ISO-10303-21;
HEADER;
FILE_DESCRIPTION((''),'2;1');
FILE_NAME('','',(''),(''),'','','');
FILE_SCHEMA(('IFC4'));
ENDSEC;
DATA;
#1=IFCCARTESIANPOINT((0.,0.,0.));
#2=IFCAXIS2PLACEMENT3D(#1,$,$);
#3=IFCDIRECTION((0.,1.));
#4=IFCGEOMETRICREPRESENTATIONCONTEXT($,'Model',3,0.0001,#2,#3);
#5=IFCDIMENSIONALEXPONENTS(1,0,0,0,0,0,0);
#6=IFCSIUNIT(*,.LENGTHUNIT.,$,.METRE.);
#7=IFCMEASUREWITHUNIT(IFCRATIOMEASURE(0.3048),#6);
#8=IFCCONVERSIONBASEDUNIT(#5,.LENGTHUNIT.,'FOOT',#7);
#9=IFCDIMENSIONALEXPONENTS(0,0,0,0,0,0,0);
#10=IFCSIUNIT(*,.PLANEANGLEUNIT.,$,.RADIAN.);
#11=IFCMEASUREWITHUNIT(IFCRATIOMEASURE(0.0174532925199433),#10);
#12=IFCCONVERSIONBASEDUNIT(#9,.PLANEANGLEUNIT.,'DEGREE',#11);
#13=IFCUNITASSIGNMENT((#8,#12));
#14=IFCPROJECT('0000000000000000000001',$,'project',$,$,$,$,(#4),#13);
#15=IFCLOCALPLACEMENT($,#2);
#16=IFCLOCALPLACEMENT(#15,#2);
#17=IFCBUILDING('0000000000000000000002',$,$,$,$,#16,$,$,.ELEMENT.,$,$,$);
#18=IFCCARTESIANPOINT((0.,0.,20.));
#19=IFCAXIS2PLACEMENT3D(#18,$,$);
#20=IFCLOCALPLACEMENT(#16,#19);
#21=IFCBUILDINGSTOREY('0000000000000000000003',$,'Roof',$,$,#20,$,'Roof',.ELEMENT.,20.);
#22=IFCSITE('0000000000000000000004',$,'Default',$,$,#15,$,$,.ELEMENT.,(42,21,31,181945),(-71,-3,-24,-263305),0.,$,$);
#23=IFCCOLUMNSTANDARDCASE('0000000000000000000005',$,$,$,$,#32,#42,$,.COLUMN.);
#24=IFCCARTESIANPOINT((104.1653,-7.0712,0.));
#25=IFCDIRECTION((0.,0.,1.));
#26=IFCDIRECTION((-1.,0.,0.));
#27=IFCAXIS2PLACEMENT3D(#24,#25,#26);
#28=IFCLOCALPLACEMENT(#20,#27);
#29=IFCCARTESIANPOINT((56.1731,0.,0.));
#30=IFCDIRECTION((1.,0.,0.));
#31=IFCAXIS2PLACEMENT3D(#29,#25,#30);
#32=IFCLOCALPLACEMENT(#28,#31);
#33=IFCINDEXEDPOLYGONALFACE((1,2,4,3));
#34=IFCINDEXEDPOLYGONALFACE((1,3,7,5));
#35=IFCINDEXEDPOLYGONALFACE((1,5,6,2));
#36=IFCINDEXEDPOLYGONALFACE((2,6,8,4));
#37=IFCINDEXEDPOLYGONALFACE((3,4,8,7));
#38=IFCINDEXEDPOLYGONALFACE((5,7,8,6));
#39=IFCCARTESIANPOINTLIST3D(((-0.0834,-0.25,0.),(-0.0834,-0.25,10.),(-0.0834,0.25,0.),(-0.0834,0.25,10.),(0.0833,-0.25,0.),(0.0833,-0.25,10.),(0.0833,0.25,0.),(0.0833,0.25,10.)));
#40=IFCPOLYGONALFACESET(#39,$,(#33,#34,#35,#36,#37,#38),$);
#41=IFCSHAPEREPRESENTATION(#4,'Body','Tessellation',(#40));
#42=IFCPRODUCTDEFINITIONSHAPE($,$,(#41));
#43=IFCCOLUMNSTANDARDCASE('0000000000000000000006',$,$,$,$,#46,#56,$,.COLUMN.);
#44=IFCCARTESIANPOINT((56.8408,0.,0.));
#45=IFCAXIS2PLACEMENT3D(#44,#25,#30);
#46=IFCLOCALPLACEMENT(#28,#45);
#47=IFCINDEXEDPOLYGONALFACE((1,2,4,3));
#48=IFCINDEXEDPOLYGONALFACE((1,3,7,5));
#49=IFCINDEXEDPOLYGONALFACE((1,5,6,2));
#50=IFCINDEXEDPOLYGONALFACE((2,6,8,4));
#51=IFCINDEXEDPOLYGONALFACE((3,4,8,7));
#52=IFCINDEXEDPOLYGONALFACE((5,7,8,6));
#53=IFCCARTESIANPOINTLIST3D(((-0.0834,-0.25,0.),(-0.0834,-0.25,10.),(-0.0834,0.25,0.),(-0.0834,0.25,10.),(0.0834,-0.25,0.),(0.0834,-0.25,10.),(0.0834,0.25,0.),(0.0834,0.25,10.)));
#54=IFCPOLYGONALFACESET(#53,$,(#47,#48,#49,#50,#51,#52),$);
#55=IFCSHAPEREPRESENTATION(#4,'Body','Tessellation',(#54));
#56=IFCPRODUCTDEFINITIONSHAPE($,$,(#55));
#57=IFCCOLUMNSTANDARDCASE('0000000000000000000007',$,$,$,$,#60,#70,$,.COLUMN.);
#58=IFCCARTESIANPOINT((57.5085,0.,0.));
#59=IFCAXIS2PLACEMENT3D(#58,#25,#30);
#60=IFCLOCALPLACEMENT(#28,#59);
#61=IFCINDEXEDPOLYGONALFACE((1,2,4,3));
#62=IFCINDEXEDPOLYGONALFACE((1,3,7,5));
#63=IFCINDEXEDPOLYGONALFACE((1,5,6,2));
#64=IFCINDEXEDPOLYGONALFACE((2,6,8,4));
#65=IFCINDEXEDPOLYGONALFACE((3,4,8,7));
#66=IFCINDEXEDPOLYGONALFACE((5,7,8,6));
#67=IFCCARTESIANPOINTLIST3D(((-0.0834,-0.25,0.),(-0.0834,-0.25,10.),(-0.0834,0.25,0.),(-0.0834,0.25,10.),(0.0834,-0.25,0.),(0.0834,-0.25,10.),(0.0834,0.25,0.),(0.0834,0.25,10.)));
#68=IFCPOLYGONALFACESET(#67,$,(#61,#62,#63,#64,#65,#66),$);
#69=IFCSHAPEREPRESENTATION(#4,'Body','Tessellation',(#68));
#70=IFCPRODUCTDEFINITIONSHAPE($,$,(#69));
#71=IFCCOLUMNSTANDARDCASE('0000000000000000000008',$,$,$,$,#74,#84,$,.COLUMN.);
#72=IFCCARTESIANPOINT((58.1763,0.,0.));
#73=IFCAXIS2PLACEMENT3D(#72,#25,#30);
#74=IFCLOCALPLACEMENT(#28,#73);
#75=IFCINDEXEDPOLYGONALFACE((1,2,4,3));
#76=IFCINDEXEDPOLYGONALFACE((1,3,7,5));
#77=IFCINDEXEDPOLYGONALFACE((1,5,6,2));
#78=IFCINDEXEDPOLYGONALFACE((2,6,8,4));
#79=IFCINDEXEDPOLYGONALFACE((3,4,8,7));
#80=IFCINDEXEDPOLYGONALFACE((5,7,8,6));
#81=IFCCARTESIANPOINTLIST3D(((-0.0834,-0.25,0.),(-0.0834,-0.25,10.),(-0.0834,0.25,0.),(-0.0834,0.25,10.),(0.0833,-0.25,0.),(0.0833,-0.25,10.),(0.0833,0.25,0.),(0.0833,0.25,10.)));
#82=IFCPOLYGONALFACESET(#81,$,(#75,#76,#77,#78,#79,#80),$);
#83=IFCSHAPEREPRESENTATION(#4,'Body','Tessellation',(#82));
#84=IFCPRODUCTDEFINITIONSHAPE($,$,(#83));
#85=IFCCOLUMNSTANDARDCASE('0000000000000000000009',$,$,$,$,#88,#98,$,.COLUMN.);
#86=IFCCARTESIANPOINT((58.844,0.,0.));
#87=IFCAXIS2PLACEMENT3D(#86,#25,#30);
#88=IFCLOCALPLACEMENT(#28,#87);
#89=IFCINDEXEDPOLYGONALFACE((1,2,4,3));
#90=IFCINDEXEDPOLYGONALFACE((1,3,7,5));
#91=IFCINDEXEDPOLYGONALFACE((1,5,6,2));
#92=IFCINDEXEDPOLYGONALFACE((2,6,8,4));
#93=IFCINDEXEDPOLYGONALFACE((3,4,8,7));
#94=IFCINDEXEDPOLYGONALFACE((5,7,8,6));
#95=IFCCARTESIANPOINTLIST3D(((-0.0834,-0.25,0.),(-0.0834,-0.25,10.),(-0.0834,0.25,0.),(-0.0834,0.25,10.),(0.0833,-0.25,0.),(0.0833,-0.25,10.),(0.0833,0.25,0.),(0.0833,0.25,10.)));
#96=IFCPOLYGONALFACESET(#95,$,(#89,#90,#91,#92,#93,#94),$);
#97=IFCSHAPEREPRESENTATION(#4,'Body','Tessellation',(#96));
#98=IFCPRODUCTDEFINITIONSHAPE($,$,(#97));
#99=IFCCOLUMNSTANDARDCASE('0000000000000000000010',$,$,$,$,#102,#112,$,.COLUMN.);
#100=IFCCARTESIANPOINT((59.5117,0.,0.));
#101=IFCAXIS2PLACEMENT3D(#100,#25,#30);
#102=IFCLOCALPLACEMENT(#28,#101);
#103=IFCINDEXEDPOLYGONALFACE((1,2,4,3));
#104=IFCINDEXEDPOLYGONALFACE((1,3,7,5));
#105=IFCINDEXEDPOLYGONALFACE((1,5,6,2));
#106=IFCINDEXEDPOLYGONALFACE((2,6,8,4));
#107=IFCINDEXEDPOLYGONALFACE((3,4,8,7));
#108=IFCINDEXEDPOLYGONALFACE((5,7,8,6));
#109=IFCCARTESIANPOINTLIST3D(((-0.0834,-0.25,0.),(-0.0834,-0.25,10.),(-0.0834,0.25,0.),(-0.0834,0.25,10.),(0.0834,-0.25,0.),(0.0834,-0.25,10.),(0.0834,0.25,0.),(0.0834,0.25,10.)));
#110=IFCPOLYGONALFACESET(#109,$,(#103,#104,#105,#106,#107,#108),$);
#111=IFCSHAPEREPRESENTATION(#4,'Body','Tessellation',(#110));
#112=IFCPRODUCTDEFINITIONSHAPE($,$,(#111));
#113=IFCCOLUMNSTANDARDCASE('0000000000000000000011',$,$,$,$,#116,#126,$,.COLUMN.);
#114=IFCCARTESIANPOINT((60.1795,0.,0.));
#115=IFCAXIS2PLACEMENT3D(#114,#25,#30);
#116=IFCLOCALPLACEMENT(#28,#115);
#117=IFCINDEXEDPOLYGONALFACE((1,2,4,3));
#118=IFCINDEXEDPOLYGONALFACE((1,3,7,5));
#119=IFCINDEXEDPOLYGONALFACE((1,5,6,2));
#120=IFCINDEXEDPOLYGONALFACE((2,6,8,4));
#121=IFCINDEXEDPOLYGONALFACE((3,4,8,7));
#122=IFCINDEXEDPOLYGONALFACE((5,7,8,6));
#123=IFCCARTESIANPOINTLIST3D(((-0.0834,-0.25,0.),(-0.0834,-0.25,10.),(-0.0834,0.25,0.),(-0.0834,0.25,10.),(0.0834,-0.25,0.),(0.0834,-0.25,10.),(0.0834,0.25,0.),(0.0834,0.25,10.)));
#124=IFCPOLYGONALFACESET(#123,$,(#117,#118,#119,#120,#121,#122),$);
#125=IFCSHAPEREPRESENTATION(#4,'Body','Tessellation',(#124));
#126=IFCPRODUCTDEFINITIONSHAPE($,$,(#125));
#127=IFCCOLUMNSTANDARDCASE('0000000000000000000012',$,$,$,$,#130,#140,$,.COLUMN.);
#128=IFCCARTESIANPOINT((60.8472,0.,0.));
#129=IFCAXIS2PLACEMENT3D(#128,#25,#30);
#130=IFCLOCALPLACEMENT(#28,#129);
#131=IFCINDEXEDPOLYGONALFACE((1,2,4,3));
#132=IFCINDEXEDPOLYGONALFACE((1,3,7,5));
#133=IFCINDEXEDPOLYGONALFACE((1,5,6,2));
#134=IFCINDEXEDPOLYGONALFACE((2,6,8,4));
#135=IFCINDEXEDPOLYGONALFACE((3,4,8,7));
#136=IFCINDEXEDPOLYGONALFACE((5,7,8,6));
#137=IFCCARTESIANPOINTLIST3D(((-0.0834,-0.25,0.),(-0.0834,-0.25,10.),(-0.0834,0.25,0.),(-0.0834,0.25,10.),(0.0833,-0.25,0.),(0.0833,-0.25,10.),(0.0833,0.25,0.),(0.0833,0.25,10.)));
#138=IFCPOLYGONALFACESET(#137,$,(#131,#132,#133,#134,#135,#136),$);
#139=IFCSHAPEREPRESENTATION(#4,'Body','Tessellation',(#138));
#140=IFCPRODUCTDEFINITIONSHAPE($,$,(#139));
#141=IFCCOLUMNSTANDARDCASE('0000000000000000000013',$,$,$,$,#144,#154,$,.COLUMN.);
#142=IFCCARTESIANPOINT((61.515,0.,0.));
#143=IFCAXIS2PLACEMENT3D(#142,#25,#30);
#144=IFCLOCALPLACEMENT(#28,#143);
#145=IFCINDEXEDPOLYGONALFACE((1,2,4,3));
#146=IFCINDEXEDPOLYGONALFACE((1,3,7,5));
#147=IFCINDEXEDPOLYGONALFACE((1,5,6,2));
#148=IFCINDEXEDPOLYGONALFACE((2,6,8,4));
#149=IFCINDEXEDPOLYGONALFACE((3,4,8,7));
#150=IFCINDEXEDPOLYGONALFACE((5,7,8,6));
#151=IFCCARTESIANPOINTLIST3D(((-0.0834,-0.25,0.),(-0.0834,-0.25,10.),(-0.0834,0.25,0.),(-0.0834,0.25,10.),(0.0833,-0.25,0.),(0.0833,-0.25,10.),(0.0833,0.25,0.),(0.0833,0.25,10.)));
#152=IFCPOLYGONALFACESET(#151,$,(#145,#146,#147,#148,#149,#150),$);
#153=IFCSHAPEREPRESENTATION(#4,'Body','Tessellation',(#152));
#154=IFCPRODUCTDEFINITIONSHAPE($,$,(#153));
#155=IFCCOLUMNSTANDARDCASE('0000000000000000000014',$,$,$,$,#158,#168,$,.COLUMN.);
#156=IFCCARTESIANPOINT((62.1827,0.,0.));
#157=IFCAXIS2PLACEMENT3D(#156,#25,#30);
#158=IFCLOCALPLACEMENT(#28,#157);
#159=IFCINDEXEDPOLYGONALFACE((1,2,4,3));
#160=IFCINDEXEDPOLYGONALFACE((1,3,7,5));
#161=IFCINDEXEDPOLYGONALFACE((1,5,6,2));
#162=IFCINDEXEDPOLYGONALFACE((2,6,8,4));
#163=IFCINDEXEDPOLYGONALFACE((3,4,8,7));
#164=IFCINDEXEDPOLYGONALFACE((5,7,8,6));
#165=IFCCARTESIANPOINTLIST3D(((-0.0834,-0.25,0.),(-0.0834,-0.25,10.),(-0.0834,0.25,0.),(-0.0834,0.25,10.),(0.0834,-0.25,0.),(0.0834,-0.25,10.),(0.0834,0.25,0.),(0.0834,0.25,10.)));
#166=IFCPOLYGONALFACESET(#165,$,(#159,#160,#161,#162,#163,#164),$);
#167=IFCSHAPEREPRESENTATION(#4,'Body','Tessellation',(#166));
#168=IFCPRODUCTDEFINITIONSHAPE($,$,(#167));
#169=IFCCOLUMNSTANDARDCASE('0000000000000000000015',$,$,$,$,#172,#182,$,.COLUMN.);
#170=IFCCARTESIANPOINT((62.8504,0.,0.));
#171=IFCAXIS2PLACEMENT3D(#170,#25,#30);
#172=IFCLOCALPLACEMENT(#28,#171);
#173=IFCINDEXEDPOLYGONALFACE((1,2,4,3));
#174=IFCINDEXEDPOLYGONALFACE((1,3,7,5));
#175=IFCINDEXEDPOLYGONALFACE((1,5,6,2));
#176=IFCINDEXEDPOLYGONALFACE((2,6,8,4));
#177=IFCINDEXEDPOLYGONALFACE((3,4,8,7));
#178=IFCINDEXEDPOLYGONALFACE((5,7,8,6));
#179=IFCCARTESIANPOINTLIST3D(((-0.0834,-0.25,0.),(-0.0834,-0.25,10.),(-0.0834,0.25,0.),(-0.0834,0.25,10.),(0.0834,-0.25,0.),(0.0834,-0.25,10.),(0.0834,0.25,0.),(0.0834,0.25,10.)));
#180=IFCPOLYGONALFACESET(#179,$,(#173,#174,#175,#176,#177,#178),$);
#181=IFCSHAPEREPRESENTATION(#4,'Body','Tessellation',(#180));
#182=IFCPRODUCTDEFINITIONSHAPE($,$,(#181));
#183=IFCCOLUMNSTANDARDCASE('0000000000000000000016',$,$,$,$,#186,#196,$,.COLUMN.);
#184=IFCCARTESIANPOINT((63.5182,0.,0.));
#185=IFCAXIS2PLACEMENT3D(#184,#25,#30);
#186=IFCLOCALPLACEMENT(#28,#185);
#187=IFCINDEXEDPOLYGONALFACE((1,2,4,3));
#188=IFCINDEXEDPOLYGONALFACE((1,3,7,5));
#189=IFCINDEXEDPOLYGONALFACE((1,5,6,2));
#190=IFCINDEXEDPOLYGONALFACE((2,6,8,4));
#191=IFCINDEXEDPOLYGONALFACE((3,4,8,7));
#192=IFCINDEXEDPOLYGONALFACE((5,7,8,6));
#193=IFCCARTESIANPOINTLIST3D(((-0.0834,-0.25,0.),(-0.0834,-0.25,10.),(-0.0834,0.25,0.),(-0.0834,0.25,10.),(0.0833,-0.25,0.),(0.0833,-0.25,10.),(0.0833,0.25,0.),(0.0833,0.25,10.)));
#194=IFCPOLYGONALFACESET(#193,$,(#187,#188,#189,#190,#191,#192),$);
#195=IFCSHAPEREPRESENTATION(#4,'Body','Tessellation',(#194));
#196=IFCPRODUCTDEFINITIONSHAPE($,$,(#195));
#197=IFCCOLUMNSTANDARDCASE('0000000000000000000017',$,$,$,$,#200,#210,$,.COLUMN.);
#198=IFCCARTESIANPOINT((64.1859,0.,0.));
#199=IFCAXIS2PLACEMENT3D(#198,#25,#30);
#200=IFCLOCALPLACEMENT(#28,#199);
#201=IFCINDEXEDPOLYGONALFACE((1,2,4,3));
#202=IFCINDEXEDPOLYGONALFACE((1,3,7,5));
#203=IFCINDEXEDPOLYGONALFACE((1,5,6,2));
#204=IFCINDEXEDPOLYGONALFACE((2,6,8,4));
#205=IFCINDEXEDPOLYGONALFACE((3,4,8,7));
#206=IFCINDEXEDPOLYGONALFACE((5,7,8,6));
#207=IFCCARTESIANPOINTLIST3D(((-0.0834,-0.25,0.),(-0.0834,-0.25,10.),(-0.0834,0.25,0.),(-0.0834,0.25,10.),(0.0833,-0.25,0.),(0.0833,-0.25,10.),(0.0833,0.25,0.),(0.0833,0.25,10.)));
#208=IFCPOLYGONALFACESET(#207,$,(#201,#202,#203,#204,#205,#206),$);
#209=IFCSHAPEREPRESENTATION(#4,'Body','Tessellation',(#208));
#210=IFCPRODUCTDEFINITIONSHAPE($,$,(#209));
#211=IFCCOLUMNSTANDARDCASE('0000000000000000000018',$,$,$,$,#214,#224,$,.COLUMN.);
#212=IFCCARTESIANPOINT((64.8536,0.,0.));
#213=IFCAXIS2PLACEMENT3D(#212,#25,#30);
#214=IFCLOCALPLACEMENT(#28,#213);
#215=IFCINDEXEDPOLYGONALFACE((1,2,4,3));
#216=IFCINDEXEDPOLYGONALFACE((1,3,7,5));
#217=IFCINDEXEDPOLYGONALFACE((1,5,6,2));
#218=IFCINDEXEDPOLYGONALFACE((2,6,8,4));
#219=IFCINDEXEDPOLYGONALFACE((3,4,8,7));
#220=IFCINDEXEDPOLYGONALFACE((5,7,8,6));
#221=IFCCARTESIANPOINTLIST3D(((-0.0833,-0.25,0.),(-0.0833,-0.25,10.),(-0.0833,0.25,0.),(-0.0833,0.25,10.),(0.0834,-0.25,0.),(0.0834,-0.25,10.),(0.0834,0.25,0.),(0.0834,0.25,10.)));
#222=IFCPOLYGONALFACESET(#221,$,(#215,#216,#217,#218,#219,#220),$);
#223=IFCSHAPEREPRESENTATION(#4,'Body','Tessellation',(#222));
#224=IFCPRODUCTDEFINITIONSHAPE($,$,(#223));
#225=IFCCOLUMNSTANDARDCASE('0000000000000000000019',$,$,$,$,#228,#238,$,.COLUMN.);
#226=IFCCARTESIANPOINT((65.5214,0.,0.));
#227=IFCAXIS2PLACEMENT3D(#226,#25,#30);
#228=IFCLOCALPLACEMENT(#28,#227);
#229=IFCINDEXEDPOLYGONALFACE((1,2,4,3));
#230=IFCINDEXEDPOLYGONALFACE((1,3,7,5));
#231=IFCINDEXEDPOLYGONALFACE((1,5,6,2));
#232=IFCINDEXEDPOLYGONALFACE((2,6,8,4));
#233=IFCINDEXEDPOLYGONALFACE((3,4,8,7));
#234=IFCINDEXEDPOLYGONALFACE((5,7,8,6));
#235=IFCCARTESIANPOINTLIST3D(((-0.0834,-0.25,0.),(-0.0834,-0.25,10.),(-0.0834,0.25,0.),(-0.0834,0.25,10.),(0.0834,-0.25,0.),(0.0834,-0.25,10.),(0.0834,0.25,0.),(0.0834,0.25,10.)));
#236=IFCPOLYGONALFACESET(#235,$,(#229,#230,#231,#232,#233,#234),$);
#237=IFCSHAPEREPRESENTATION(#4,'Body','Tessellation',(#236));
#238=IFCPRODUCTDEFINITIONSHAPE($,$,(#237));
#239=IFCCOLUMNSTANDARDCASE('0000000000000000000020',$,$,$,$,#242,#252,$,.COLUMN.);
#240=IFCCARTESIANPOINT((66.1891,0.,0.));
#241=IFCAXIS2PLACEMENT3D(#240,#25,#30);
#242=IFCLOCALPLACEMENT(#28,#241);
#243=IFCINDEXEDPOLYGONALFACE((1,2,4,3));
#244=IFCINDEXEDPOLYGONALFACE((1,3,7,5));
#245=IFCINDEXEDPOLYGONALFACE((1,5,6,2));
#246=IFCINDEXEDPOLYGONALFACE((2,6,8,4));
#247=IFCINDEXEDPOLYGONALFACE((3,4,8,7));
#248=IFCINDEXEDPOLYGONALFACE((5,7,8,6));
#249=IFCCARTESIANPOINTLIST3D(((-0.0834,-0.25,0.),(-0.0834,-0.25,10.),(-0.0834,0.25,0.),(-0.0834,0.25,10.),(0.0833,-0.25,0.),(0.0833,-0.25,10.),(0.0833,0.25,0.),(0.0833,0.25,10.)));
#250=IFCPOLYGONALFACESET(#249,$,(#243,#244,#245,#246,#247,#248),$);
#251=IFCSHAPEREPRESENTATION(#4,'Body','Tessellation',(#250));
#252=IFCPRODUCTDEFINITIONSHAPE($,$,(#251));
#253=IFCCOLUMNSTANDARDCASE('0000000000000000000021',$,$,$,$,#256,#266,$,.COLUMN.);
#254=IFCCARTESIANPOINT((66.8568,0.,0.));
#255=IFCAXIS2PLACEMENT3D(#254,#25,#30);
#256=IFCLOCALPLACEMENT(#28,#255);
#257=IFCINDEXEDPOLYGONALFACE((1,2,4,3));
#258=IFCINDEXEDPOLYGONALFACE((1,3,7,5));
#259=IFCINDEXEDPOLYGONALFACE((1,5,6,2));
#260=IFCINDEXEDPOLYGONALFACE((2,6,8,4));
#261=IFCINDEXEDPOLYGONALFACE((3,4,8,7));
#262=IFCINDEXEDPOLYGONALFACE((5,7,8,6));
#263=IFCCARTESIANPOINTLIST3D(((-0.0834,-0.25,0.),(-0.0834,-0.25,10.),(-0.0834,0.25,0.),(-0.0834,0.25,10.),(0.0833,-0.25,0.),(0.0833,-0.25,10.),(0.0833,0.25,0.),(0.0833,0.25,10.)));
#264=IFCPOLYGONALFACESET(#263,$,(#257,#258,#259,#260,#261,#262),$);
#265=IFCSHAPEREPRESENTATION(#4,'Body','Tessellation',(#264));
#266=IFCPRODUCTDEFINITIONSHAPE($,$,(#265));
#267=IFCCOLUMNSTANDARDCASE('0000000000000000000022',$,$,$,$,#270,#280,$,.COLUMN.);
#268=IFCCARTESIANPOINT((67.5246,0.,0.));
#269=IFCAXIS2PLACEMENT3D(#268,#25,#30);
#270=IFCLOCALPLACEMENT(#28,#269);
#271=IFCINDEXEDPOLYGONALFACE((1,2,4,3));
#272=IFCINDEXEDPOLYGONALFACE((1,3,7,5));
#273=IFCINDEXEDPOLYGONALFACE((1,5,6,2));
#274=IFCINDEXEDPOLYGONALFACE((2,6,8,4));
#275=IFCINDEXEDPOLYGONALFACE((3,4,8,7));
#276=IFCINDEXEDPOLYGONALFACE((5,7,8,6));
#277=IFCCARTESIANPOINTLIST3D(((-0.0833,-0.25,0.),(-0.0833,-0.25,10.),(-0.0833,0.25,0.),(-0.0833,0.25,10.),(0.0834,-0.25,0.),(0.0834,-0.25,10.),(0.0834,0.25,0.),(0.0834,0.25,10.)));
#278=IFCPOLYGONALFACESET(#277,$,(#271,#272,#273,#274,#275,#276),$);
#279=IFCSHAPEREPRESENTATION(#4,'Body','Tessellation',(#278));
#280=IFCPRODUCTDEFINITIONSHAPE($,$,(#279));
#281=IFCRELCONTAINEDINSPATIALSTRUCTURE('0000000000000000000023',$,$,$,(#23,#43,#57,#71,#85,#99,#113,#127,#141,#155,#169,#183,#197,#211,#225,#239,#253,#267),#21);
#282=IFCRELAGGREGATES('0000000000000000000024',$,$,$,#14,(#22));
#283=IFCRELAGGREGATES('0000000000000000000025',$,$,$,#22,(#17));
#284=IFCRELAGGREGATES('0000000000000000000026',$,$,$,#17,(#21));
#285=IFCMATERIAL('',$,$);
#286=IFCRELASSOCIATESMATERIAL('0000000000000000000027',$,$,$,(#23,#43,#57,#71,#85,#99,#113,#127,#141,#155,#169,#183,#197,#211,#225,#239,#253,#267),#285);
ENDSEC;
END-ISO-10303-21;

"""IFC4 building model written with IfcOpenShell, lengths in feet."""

from ifc_helpers import new_model, entity, si_unit, converted_unit, direction, frame, origin, place, context, project, spatial, rectangle, extrude, material, element, save


model = new_model("IFC4")

# Units and contexts
model_context = context("Model", 3, precision=0.0001, world=origin(), true_north=direction((0.0, 1.0)))
ifc_project = project(units=[converted_unit("LENGTHUNIT", "FOOT", entity("IfcRatioMeasure", 0.3048), si_unit("LENGTHUNIT", "METRE"), dimensions=[1, 0, 0, 0, 0, 0, 0]), converted_unit("PLANEANGLEUNIT", "DEGREE", entity("IfcRatioMeasure", 0.0174532925199433), si_unit("PLANEANGLEUNIT", "RADIAN"), dimensions=[0, 0, 0, 0, 0, 0, 0])], contexts=[model_context])

# Site, building, storey
site_placement = place(None, origin())
site = spatial("IfcSite", under=ifc_project, at=site_placement, Name="Default", CompositionType="ELEMENT", RefLatitude=(42, 21, 31, 181945), RefLongitude=(-71, -3, -24, -263305), RefElevation=0.0)
building_placement = place(site_placement, origin())
building = spatial("IfcBuilding", under=site, at=building_placement, CompositionType="ELEMENT")
storey_placement = place(building_placement, frame((0.0, 0.0, 20.0)))
storey = spatial("IfcBuildingStorey", under=building, at=storey_placement, Name="Roof", LongName="Roof", CompositionType="ELEMENT", Elevation=20.0)

# Columns
ifc_material_1 = material(Name="")
placement_1 = place(storey_placement, frame((104.1653, -7.0712, 0.0), z_axis=(0.0, 0.0, 1.0), x_axis=(-1.0, 0.0, 0.0)))
for number, where, z_axis, x_axis in (
    (1, (56.1731, 0.0, 0.0), (0.0, 0.0, 1.0), (1.0, 0.0, 0.0)),
    (2, (56.8408, 0.0, 0.0), (0.0, 0.0, 1.0), (1.0, 0.0, 0.0)),
    (3, (57.5085, 0.0, 0.0), (0.0, 0.0, 1.0), (1.0, 0.0, 0.0)),
    (4, (58.1763, 0.0, 0.0), (0.0, 0.0, 1.0), (1.0, 0.0, 0.0)),
    (5, (58.844, 0.0, 0.0), (0.0, 0.0, 1.0), (1.0, 0.0, 0.0)),
    (6, (59.5117, 0.0, 0.0), (0.0, 0.0, 1.0), (1.0, 0.0, 0.0)),
    (7, (60.1795, 0.0, 0.0), (0.0, 0.0, 1.0), (1.0, 0.0, 0.0)),
    (8, (60.8472, 0.0, 0.0), (0.0, 0.0, 1.0), (1.0, 0.0, 0.0)),
    (9, (61.515, 0.0, 0.0), (0.0, 0.0, 1.0), (1.0, 0.0, 0.0)),
    (10, (62.1827, 0.0, 0.0), (0.0, 0.0, 1.0), (1.0, 0.0, 0.0)),
    (11, (62.8504, 0.0, 0.0), (0.0, 0.0, 1.0), (1.0, 0.0, 0.0)),
    (12, (63.5182, 0.0, 0.0), (0.0, 0.0, 1.0), (1.0, 0.0, 0.0)),
    (13, (64.1859, 0.0, 0.0), (0.0, 0.0, 1.0), (1.0, 0.0, 0.0)),
    (14, (64.8536, 0.0, 0.0), (0.0, 0.0, 1.0), (1.0, 0.0, 0.0)),
    (15, (65.5214, 0.0, 0.0), (0.0, 0.0, 1.0), (1.0, 0.0, 0.0)),
    (16, (66.1891, 0.0, 0.0), (0.0, 0.0, 1.0), (1.0, 0.0, 0.0)),
    (17, (66.8568, 0.0, 0.0), (0.0, 0.0, 1.0), (1.0, 0.0, 0.0)),
    (18, (67.5246, 0.0, 0.0), (0.0, 0.0, 1.0), (1.0, 0.0, 0.0)),
):
    element("IfcColumnStandardCase", number, at=place(placement_1, frame(where, z_axis=z_axis, x_axis=x_axis)), inside=storey, material=ifc_material_1, PredefinedType="COLUMN", context=model_context, shape_type="SweptSolid", body=[
        extrude(rectangle(XDim=0.1667, YDim=0.5), origin(), (0.0, 0.0, 1.0), 10.0),
    ])

save(model, "model.ifc")
